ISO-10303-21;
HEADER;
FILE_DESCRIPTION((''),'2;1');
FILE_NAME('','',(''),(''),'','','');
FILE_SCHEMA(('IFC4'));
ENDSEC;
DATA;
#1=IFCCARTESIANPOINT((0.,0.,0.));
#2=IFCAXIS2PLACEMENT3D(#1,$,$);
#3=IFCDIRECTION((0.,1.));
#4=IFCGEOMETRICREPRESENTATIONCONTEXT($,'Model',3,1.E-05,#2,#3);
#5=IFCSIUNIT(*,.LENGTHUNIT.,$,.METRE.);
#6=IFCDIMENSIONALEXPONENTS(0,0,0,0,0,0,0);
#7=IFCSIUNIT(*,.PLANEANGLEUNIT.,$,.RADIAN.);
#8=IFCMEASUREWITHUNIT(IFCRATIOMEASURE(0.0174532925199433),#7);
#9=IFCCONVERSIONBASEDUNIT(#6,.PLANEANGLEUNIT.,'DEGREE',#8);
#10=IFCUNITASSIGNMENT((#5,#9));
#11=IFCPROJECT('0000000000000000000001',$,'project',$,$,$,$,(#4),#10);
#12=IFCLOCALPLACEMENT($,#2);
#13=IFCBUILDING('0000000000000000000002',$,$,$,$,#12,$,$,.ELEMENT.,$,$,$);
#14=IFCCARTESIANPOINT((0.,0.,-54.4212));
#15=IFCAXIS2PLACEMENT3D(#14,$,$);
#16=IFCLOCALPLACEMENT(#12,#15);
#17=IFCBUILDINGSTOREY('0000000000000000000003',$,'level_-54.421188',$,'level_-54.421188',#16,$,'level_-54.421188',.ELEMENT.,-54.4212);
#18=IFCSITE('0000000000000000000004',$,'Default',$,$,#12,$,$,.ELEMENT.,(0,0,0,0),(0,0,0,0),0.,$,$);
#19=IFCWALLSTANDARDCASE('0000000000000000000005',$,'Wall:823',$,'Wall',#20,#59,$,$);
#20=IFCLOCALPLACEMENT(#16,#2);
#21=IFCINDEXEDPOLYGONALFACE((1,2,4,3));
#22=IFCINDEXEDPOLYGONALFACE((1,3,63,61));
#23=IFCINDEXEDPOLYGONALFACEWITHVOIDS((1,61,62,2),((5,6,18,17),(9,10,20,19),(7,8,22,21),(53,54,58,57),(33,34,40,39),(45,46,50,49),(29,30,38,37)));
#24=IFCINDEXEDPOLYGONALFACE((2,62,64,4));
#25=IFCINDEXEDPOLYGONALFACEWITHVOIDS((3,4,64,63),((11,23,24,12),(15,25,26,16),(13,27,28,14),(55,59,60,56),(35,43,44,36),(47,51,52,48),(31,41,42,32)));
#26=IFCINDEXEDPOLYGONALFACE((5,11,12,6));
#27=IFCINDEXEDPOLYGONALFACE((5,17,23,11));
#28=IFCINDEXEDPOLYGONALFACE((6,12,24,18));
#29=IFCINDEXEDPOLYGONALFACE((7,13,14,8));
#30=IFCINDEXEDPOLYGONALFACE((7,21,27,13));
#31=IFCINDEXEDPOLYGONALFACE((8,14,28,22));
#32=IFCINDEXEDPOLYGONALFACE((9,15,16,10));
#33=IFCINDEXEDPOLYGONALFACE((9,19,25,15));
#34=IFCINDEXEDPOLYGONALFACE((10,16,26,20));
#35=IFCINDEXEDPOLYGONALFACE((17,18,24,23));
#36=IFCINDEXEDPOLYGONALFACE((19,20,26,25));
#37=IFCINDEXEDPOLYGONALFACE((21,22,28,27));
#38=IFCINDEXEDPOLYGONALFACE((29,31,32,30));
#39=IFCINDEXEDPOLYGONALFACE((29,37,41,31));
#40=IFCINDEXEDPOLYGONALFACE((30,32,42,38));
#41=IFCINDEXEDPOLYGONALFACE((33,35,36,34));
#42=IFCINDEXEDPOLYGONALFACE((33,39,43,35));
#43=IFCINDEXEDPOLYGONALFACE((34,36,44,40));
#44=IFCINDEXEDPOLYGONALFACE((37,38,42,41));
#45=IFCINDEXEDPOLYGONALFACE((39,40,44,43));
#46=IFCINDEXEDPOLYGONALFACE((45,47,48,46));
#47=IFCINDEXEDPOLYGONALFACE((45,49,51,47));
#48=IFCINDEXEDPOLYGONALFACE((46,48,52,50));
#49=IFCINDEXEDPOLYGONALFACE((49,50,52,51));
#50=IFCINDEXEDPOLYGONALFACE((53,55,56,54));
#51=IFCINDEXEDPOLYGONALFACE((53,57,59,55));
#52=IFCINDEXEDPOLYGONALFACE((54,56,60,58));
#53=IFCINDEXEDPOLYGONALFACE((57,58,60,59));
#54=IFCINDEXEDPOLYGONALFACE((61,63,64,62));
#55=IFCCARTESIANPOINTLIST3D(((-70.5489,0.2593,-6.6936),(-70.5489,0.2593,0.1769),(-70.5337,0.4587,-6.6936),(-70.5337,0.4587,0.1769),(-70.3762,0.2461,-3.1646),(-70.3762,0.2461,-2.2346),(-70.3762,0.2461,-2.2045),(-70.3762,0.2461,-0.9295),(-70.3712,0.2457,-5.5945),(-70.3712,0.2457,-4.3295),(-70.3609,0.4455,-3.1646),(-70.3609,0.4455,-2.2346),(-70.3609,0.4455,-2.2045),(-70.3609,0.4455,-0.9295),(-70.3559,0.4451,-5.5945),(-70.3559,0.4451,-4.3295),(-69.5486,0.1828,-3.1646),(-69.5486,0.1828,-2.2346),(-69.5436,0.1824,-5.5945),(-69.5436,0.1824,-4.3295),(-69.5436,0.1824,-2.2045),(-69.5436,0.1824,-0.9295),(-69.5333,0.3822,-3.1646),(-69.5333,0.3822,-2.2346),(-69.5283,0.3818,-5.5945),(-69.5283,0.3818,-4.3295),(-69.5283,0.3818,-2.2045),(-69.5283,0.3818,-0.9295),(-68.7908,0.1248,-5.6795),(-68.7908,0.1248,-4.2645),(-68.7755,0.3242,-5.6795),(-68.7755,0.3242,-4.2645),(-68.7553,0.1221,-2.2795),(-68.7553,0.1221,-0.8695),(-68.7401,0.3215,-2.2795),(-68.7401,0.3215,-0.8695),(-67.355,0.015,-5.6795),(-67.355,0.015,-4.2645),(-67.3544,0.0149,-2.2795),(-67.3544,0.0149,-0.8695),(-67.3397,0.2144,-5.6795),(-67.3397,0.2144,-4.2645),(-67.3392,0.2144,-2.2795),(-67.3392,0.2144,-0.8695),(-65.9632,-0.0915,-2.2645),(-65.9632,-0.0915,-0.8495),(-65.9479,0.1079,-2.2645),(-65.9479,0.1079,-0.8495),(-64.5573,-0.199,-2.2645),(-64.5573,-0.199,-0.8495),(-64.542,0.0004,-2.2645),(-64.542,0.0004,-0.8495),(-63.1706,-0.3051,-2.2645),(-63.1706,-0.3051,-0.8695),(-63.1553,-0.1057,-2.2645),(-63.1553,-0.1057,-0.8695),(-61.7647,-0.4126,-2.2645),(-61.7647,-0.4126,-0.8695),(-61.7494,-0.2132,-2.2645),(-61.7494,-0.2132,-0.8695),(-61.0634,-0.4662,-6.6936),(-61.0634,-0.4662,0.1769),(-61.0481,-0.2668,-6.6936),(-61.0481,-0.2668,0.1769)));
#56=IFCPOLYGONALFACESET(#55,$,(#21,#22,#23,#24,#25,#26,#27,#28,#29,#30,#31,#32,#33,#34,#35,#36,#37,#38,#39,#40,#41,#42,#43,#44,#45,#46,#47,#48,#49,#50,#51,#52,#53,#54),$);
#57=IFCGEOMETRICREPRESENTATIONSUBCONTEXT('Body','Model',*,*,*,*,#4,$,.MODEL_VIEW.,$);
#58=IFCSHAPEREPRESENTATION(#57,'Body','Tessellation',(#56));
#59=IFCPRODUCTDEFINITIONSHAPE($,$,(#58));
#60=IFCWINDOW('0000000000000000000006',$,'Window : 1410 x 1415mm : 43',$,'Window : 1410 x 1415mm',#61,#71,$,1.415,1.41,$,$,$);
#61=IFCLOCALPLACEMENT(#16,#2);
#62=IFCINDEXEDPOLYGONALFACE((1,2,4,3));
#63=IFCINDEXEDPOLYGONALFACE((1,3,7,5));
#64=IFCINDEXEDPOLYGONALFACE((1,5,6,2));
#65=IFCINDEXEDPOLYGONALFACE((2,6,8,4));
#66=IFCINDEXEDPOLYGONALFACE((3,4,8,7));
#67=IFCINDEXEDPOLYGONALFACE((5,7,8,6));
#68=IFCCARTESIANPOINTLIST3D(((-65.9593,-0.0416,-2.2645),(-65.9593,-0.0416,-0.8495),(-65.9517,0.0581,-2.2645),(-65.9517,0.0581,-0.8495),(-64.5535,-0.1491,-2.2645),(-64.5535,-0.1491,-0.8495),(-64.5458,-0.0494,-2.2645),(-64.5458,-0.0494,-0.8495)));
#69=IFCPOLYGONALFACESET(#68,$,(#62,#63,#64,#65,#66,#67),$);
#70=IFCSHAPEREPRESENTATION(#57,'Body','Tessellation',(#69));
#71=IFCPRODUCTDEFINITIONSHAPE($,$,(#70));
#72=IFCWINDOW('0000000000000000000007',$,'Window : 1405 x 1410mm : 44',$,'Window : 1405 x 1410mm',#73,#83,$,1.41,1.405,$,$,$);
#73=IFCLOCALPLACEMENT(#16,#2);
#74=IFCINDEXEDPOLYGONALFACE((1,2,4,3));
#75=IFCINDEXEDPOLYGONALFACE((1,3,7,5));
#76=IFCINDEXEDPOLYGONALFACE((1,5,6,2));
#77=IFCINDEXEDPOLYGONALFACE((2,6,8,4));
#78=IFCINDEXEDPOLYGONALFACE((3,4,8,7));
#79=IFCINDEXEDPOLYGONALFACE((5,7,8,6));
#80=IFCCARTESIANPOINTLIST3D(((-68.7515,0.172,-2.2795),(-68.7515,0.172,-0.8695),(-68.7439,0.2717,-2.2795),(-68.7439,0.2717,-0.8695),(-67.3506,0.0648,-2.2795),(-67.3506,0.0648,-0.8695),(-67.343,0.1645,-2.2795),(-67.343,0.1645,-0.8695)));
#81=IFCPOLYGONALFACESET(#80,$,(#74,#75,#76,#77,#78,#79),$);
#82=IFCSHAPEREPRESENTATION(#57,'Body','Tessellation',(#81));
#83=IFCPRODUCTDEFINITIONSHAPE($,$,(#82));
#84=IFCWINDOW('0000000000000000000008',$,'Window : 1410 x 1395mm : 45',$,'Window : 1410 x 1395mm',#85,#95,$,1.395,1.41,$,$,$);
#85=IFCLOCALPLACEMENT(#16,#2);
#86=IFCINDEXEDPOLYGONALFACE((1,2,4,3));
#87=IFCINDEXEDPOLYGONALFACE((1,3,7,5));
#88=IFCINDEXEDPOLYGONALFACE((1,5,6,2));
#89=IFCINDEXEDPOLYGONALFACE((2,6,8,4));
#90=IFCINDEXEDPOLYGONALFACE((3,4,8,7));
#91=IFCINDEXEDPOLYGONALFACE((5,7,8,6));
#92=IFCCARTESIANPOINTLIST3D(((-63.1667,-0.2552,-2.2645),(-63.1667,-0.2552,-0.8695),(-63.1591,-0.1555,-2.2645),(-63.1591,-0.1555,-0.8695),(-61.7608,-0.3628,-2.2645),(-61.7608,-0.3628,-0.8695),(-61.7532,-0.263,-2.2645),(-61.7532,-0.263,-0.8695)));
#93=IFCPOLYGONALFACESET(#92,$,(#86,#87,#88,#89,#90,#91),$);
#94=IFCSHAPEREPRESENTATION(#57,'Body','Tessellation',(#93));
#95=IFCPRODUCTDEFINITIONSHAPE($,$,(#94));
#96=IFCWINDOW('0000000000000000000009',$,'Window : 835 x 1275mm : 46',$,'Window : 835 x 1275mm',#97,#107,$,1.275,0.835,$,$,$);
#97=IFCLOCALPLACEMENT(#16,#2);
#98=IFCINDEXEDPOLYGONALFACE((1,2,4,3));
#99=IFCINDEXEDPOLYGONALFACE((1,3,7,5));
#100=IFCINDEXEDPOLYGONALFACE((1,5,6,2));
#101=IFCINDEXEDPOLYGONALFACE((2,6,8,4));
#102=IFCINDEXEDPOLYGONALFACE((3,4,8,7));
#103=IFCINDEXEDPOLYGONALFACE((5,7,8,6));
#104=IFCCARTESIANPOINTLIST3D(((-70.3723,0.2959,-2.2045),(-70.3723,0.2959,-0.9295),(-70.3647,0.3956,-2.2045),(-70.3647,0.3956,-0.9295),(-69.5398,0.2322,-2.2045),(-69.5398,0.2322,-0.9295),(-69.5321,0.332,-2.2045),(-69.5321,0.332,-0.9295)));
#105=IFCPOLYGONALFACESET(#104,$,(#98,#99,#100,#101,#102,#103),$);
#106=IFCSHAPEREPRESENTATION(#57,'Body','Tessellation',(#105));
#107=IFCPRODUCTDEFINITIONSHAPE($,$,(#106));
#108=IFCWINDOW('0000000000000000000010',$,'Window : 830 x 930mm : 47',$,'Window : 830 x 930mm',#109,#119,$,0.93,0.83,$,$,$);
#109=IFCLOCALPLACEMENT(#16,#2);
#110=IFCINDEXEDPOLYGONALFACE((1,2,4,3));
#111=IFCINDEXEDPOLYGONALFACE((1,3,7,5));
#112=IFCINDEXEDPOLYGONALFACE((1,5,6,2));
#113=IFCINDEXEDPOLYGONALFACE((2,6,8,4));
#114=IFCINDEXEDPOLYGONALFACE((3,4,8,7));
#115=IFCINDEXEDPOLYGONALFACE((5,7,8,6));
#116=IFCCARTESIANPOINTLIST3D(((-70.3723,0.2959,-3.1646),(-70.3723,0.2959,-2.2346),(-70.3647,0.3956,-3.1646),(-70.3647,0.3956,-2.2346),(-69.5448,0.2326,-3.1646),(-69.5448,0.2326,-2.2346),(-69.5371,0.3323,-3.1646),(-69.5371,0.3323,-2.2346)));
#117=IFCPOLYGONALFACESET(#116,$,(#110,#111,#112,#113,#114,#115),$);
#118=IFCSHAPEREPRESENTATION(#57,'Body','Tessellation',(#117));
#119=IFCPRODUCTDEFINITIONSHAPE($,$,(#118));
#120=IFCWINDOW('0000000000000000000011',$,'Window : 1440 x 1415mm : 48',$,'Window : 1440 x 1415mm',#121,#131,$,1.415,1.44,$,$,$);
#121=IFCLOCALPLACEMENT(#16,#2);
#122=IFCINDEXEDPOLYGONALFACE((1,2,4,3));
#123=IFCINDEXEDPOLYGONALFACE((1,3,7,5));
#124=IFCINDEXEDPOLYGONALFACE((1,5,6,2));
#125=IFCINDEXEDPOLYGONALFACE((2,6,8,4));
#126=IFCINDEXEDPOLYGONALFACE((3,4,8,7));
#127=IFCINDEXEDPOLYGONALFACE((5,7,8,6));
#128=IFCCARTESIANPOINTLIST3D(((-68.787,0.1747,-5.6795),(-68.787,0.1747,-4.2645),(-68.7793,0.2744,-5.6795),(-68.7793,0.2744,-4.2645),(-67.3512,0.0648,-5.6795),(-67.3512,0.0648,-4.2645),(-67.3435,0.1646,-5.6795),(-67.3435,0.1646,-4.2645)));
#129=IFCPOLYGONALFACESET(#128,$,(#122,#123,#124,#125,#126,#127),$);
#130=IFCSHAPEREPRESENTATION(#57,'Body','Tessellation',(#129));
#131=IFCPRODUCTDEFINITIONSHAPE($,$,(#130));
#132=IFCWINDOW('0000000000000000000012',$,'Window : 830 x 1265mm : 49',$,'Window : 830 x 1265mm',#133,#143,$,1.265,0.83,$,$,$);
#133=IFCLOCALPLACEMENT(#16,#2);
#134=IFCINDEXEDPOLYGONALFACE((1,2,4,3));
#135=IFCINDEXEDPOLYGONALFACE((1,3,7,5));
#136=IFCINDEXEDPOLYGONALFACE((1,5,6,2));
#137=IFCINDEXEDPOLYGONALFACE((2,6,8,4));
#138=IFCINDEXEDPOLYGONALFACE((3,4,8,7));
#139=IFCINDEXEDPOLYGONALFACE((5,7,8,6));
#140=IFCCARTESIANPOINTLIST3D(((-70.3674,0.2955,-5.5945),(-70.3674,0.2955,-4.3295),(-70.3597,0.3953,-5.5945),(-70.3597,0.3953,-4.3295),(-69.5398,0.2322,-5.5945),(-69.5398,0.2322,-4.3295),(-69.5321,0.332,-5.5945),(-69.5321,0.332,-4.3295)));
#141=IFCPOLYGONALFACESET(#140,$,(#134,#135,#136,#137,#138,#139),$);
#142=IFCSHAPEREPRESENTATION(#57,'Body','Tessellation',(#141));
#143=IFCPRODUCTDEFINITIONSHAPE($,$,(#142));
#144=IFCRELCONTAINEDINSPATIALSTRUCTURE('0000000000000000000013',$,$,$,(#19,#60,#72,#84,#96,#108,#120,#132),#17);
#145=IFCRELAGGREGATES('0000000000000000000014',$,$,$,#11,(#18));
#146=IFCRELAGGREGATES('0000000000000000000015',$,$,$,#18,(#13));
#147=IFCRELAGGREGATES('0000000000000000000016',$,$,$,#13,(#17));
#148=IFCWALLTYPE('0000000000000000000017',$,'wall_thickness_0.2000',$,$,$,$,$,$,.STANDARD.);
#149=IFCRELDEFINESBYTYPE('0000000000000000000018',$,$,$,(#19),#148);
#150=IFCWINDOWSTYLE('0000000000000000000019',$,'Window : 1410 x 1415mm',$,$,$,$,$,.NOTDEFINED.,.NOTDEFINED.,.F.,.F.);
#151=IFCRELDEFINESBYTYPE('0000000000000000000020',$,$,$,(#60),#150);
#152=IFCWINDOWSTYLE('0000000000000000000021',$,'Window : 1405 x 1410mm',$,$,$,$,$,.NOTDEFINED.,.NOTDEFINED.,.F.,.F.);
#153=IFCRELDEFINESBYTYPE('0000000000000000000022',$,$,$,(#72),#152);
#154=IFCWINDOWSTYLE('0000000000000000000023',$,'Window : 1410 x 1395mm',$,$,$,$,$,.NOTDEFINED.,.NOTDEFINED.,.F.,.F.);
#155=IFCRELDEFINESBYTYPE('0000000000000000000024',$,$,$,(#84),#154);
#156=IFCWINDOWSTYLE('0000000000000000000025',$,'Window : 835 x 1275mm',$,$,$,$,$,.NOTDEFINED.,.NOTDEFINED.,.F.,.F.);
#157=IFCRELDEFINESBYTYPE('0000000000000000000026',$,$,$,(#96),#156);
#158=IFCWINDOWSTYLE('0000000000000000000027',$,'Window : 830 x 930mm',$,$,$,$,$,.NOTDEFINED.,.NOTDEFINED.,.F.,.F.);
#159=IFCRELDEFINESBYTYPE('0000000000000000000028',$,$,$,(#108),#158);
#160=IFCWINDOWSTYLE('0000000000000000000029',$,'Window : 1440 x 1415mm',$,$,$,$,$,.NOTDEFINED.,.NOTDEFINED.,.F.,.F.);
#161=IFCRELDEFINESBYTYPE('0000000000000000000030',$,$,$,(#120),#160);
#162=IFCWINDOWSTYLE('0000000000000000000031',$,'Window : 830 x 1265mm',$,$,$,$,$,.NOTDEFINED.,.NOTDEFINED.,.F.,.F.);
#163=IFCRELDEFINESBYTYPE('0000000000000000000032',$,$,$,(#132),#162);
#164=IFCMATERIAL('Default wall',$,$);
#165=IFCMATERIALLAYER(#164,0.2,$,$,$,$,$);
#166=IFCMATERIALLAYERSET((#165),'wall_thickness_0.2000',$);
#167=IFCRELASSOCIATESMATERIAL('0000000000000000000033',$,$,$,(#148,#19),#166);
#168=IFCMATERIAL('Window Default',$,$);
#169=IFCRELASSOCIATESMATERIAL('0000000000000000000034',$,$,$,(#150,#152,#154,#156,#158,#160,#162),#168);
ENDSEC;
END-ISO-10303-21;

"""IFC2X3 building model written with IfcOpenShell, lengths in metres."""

from ifc_helpers import new_model, entity, si_unit, converted_unit, direction, frame, frame_2d, origin, origin_2d_with_axis, place, context, subcontext, project, spatial, polyline, rectangle, outline, extrude, source, transform, mapped, material, layer, layer_set, layer_usage, type_object, type_shapes, element, fill, save


model = new_model("IFC2X3")

# Units and contexts
model_context = context("Model", 3, precision=1e-05, world=origin(), true_north=direction((0.0, 1.0)))
body_context = subcontext(model_context, "Body", "Model", "MODEL_VIEW")
ifc_project = project(units=[si_unit("LENGTHUNIT", "METRE"), converted_unit("PLANEANGLEUNIT", "DEGREE", entity("IfcRatioMeasure", 0.0174532925199433), si_unit("PLANEANGLEUNIT", "RADIAN"), dimensions=[0, 0, 0, 0, 0, 0, 0])], contexts=[model_context])

# Site, building, storey
placement_1 = place(None, origin())
site = spatial("IfcSite", under=ifc_project, at=placement_1, Name="Default", CompositionType="ELEMENT", RefLatitude=(0, 0, 0, 0), RefLongitude=(0, 0, 0, 0), RefElevation=0.0)
building = spatial("IfcBuilding", under=site, at=placement_1, CompositionType="ELEMENT")
storey_placement = place(placement_1, frame((0.0, 0.0, -54.4212)))
storey = spatial("IfcBuildingStorey", under=building, at=storey_placement, Name="level_-54.421188", ObjectType="level_-54.421188", LongName="level_-54.421188", CompositionType="ELEMENT", Elevation=-54.4212)

# Wall, openings, windows
ifc_material_1 = material(Name="Default wall")
ifc_layer = layer(ifc_material_1, 0.2)
ifc_layer_set = layer_set([ifc_layer], Name="wall_thickness_0.2000")
ifc_layer_usage = layer_usage(ifc_layer_set, "AXIS2", "POSITIVE", -0.1)
wall_type = type_object("IfcWallType", Name="wall_thickness_0.2000", PredefinedType="STANDARD", material=ifc_layer_set)
placement_2 = place(placement_1, frame((0.0, 0.0, -61.1148)))
wall_1_placement = place(placement_2, frame((-70.5413, 0.359, 0.0), z_axis=(0.0, 0.0, 1.0), x_axis=(0.997088, -0.076266, 0.0)))
wall_1 = element("IfcWallStandardCase", 1, at=wall_1_placement, inside=storey, type_object=wall_type, material=ifc_layer_usage, Name="Wall:823", ObjectType="Wall", context=body_context, shape_type="SweptSolid", body=[
    extrude(outline(polyline([(9.5133, -0.1), (9.5133, 0.1), (0.0, 0.1), (0.0, -0.1), (9.5133, -0.1)])), origin(), (0.0, 0.0, 1.0), 6.8705),
])
opening_1_placement = place(wall_1_placement, frame((4.5991, -0.1, 4.4291)))
opening_1 = element("IfcOpeningElement", 2, at=opening_1_placement, cuts=wall_1, ObjectType="Opening", context=body_context, shape_type="SweptSolid", body=[
    extrude(rectangle(XDim=1.41, YDim=1.415, at=frame_2d((0.7075, 0.705), x_axis=(0.0, 1.0))), frame((0.0, 0.0, 0.0), z_axis=(0.0, 1.0, 0.0), x_axis=(0.0, 0.0, 1.0)), (0.0, 0.0, 1.0), 0.2),
])
opening_2_placement = place(wall_1_placement, frame((1.7988, -0.1, 4.4141)))
opening_2 = element("IfcOpeningElement", 3, at=opening_2_placement, cuts=wall_1, ObjectType="Opening", context=body_context, shape_type="SweptSolid", body=[
    extrude(rectangle(XDim=1.405, YDim=1.41, at=frame_2d((0.705, 0.7025), x_axis=(0.0, 1.0))), frame((0.0, 0.0, 0.0), z_axis=(0.0, 1.0, 0.0), x_axis=(0.0, 0.0, 1.0)), (0.0, 0.0, 1.0), 0.2),
])
opening_3_placement = place(wall_1_placement, frame((7.3999, -0.1, 4.4291)))
opening_3 = element("IfcOpeningElement", 4, at=opening_3_placement, cuts=wall_1, ObjectType="Opening", context=body_context, shape_type="SweptSolid", body=[
    extrude(rectangle(XDim=1.41, YDim=1.395, at=frame_2d((0.6975, 0.705), x_axis=(0.0, 1.0))), frame((0.0, 0.0, 0.0), z_axis=(0.0, 1.0, 0.0), x_axis=(0.0, 0.0, 1.0)), (0.0, 0.0, 1.0), 0.2),
])
opening_4_placement = place(wall_1_placement, frame((0.1733, -0.1, 4.4891)))
opening_4 = element("IfcOpeningElement", 5, at=opening_4_placement, cuts=wall_1, ObjectType="Opening", context=body_context, shape_type="SweptSolid", body=[
    extrude(rectangle(XDim=0.835, YDim=1.275, at=frame_2d((0.6375, 0.4175), x_axis=(0.0, 1.0))), frame((0.0, 0.0, 0.0), z_axis=(0.0, 1.0, 0.0), x_axis=(0.0, 0.0, 1.0)), (0.0, 0.0, 1.0), 0.2),
])
opening_5_placement = place(wall_1_placement, frame((0.1733, -0.1, 3.5291)))
opening_5 = element("IfcOpeningElement", 6, at=opening_5_placement, cuts=wall_1, ObjectType="Opening", context=body_context, shape_type="SweptSolid", body=[
    extrude(rectangle(XDim=0.83, YDim=0.93, at=frame_2d((0.465, 0.415), x_axis=(0.0, 1.0))), frame((0.0, 0.0, 0.0), z_axis=(0.0, 1.0, 0.0), x_axis=(0.0, 0.0, 1.0)), (0.0, 0.0, 1.0), 0.2),
])
opening_6_placement = place(wall_1_placement, frame((1.7633, -0.1, 1.0141)))
opening_6 = element("IfcOpeningElement", 7, at=opening_6_placement, cuts=wall_1, ObjectType="Opening", context=body_context, shape_type="SweptSolid", body=[
    extrude(rectangle(XDim=1.44, YDim=1.415, at=frame_2d((0.7075, 0.72), x_axis=(0.0, 1.0))), frame((0.0, 0.0, 0.0), z_axis=(0.0, 1.0, 0.0), x_axis=(0.0, 0.0, 1.0)), (0.0, 0.0, 1.0), 0.2),
])
opening_7_placement = place(wall_1_placement, frame((0.1783, -0.1, 1.0991)))
opening_7 = element("IfcOpeningElement", 8, at=opening_7_placement, cuts=wall_1, ObjectType="Opening", context=body_context, shape_type="SweptSolid", body=[
    extrude(rectangle(XDim=0.83, YDim=1.265, at=frame_2d((0.6325, 0.415), x_axis=(0.0, 1.0))), frame((0.0, 0.0, 0.0), z_axis=(0.0, 1.0, 0.0), x_axis=(0.0, 0.0, 1.0)), (0.0, 0.0, 1.0), 0.2),
])
ifc_material_2 = material(Name="Window Default")
window_style_1 = type_object("IfcWindowStyle", Name="Window : 1410 x 1415mm", ConstructionType="NOTDEFINED", OperationType="NOTDEFINED", ParameterTakesPrecedence=False, Sizeable=False, material=ifc_material_2)
shared_shape_1 = source(origin(), body_context, "Body", "SweptSolid", [
    extrude(rectangle(XDim=0.1, YDim=1.41, at=origin_2d_with_axis()), frame((0.705, 0.1, 0.0), z_axis=(0.0, 0.0, 1.0), x_axis=(0.0, 1.0, 0.0)), (0.0, 0.0, 1.0), 1.415),
])
type_shapes(window_style_1, [shared_shape_1])
window_1_placement = place(opening_1_placement, origin())
window_1 = element("IfcWindow", 9, at=window_1_placement, inside=storey, type_object=window_style_1, Name="Window : 1410 x 1415mm : 43", ObjectType="Window : 1410 x 1415mm", OverallHeight=1.415, OverallWidth=1.41, context=body_context, shape_type="MappedRepresentation", body=[
    mapped(shared_shape_1, transform((0.0, 0.0, 0.0), scale=1.0)),
])
fill(opening_1, window_1)
window_style_2 = type_object("IfcWindowStyle", Name="Window : 1405 x 1410mm", ConstructionType="NOTDEFINED", OperationType="NOTDEFINED", ParameterTakesPrecedence=False, Sizeable=False, material=ifc_material_2)
shared_shape_2 = source(origin(), body_context, "Body", "SweptSolid", [
    extrude(rectangle(XDim=0.1, YDim=1.405, at=origin_2d_with_axis()), frame((0.7025, 0.1, 0.0), z_axis=(0.0, 0.0, 1.0), x_axis=(0.0, 1.0, 0.0)), (0.0, 0.0, 1.0), 1.41),
])
type_shapes(window_style_2, [shared_shape_2])
window_2_placement = place(opening_2_placement, origin())
window_2 = element("IfcWindow", 10, at=window_2_placement, inside=storey, type_object=window_style_2, Name="Window : 1405 x 1410mm : 44", ObjectType="Window : 1405 x 1410mm", OverallHeight=1.41, OverallWidth=1.405, context=body_context, shape_type="MappedRepresentation", body=[
    mapped(shared_shape_2, transform((0.0, 0.0, 0.0), scale=1.0)),
])
fill(opening_2, window_2)
window_style_3 = type_object("IfcWindowStyle", Name="Window : 1410 x 1395mm", ConstructionType="NOTDEFINED", OperationType="NOTDEFINED", ParameterTakesPrecedence=False, Sizeable=False, material=ifc_material_2)
shared_shape_3 = source(origin(), body_context, "Body", "SweptSolid", [
    extrude(rectangle(XDim=0.1, YDim=1.41, at=origin_2d_with_axis()), frame((0.705, 0.1, 0.0), z_axis=(0.0, 0.0, 1.0), x_axis=(0.0, 1.0, 0.0)), (0.0, 0.0, 1.0), 1.395),
])
type_shapes(window_style_3, [shared_shape_3])
window_3_placement = place(opening_3_placement, origin())
window_3 = element("IfcWindow", 11, at=window_3_placement, inside=storey, type_object=window_style_3, Name="Window : 1410 x 1395mm : 45", ObjectType="Window : 1410 x 1395mm", OverallHeight=1.395, OverallWidth=1.41, context=body_context, shape_type="MappedRepresentation", body=[
    mapped(shared_shape_3, transform((0.0, 0.0, 0.0), scale=1.0)),
])
fill(opening_3, window_3)
window_style_4 = type_object("IfcWindowStyle", Name="Window : 835 x 1275mm", ConstructionType="NOTDEFINED", OperationType="NOTDEFINED", ParameterTakesPrecedence=False, Sizeable=False, material=ifc_material_2)
shared_shape_4 = source(origin(), body_context, "Body", "SweptSolid", [
    extrude(rectangle(XDim=0.1, YDim=0.835, at=origin_2d_with_axis()), frame((0.4175, 0.1, 0.0), z_axis=(0.0, 0.0, 1.0), x_axis=(0.0, 1.0, 0.0)), (0.0, 0.0, 1.0), 1.275),
])
type_shapes(window_style_4, [shared_shape_4])
window_4_placement = place(opening_4_placement, origin())
window_4 = element("IfcWindow", 12, at=window_4_placement, inside=storey, type_object=window_style_4, Name="Window : 835 x 1275mm : 46", ObjectType="Window : 835 x 1275mm", OverallHeight=1.275, OverallWidth=0.835, context=body_context, shape_type="MappedRepresentation", body=[
    mapped(shared_shape_4, transform((0.0, 0.0, 0.0), scale=1.0)),
])
fill(opening_4, window_4)
window_style_5 = type_object("IfcWindowStyle", Name="Window : 830 x 930mm", ConstructionType="NOTDEFINED", OperationType="NOTDEFINED", ParameterTakesPrecedence=False, Sizeable=False, material=ifc_material_2)
shared_shape_5 = source(origin(), body_context, "Body", "SweptSolid", [
    extrude(rectangle(XDim=0.1, YDim=0.83, at=origin_2d_with_axis()), frame((0.415, 0.1, 0.0), z_axis=(0.0, 0.0, 1.0), x_axis=(0.0, 1.0, 0.0)), (0.0, 0.0, 1.0), 0.93),
])
type_shapes(window_style_5, [shared_shape_5])
window_5_placement = place(opening_5_placement, origin())
window_5 = element("IfcWindow", 13, at=window_5_placement, inside=storey, type_object=window_style_5, Name="Window : 830 x 930mm : 47", ObjectType="Window : 830 x 930mm", OverallHeight=0.93, OverallWidth=0.83, context=body_context, shape_type="MappedRepresentation", body=[
    mapped(shared_shape_5, transform((0.0, 0.0, 0.0), scale=1.0)),
])
fill(opening_5, window_5)
window_style_6 = type_object("IfcWindowStyle", Name="Window : 1440 x 1415mm", ConstructionType="NOTDEFINED", OperationType="NOTDEFINED", ParameterTakesPrecedence=False, Sizeable=False, material=ifc_material_2)
shared_shape_6 = source(origin(), body_context, "Body", "SweptSolid", [
    extrude(rectangle(XDim=0.1, YDim=1.44, at=origin_2d_with_axis()), frame((0.72, 0.1, 0.0), z_axis=(0.0, 0.0, 1.0), x_axis=(0.0, 1.0, 0.0)), (0.0, 0.0, 1.0), 1.415),
])
type_shapes(window_style_6, [shared_shape_6])
window_6_placement = place(opening_6_placement, origin())
window_6 = element("IfcWindow", 14, at=window_6_placement, inside=storey, type_object=window_style_6, Name="Window : 1440 x 1415mm : 48", ObjectType="Window : 1440 x 1415mm", OverallHeight=1.415, OverallWidth=1.44, context=body_context, shape_type="MappedRepresentation", body=[
    mapped(shared_shape_6, transform((0.0, 0.0, 0.0), scale=1.0)),
])
fill(opening_6, window_6)
window_style_7 = type_object("IfcWindowStyle", Name="Window : 830 x 1265mm", ConstructionType="NOTDEFINED", OperationType="NOTDEFINED", ParameterTakesPrecedence=False, Sizeable=False, material=ifc_material_2)
shared_shape_7 = source(origin(), body_context, "Body", "SweptSolid", [
    extrude(rectangle(XDim=0.1, YDim=0.83, at=origin_2d_with_axis()), frame((0.415, 0.1, 0.0), z_axis=(0.0, 0.0, 1.0), x_axis=(0.0, 1.0, 0.0)), (0.0, 0.0, 1.0), 1.265),
])
type_shapes(window_style_7, [shared_shape_7])
window_7_placement = place(opening_7_placement, origin())
window_7 = element("IfcWindow", 15, at=window_7_placement, inside=storey, type_object=window_style_7, Name="Window : 830 x 1265mm : 49", ObjectType="Window : 830 x 1265mm", OverallHeight=1.265, OverallWidth=0.83, context=body_context, shape_type="MappedRepresentation", body=[
    mapped(shared_shape_7, transform((0.0, 0.0, 0.0), scale=1.0)),
])
fill(opening_7, window_7)

save(model, "model.ifc")
